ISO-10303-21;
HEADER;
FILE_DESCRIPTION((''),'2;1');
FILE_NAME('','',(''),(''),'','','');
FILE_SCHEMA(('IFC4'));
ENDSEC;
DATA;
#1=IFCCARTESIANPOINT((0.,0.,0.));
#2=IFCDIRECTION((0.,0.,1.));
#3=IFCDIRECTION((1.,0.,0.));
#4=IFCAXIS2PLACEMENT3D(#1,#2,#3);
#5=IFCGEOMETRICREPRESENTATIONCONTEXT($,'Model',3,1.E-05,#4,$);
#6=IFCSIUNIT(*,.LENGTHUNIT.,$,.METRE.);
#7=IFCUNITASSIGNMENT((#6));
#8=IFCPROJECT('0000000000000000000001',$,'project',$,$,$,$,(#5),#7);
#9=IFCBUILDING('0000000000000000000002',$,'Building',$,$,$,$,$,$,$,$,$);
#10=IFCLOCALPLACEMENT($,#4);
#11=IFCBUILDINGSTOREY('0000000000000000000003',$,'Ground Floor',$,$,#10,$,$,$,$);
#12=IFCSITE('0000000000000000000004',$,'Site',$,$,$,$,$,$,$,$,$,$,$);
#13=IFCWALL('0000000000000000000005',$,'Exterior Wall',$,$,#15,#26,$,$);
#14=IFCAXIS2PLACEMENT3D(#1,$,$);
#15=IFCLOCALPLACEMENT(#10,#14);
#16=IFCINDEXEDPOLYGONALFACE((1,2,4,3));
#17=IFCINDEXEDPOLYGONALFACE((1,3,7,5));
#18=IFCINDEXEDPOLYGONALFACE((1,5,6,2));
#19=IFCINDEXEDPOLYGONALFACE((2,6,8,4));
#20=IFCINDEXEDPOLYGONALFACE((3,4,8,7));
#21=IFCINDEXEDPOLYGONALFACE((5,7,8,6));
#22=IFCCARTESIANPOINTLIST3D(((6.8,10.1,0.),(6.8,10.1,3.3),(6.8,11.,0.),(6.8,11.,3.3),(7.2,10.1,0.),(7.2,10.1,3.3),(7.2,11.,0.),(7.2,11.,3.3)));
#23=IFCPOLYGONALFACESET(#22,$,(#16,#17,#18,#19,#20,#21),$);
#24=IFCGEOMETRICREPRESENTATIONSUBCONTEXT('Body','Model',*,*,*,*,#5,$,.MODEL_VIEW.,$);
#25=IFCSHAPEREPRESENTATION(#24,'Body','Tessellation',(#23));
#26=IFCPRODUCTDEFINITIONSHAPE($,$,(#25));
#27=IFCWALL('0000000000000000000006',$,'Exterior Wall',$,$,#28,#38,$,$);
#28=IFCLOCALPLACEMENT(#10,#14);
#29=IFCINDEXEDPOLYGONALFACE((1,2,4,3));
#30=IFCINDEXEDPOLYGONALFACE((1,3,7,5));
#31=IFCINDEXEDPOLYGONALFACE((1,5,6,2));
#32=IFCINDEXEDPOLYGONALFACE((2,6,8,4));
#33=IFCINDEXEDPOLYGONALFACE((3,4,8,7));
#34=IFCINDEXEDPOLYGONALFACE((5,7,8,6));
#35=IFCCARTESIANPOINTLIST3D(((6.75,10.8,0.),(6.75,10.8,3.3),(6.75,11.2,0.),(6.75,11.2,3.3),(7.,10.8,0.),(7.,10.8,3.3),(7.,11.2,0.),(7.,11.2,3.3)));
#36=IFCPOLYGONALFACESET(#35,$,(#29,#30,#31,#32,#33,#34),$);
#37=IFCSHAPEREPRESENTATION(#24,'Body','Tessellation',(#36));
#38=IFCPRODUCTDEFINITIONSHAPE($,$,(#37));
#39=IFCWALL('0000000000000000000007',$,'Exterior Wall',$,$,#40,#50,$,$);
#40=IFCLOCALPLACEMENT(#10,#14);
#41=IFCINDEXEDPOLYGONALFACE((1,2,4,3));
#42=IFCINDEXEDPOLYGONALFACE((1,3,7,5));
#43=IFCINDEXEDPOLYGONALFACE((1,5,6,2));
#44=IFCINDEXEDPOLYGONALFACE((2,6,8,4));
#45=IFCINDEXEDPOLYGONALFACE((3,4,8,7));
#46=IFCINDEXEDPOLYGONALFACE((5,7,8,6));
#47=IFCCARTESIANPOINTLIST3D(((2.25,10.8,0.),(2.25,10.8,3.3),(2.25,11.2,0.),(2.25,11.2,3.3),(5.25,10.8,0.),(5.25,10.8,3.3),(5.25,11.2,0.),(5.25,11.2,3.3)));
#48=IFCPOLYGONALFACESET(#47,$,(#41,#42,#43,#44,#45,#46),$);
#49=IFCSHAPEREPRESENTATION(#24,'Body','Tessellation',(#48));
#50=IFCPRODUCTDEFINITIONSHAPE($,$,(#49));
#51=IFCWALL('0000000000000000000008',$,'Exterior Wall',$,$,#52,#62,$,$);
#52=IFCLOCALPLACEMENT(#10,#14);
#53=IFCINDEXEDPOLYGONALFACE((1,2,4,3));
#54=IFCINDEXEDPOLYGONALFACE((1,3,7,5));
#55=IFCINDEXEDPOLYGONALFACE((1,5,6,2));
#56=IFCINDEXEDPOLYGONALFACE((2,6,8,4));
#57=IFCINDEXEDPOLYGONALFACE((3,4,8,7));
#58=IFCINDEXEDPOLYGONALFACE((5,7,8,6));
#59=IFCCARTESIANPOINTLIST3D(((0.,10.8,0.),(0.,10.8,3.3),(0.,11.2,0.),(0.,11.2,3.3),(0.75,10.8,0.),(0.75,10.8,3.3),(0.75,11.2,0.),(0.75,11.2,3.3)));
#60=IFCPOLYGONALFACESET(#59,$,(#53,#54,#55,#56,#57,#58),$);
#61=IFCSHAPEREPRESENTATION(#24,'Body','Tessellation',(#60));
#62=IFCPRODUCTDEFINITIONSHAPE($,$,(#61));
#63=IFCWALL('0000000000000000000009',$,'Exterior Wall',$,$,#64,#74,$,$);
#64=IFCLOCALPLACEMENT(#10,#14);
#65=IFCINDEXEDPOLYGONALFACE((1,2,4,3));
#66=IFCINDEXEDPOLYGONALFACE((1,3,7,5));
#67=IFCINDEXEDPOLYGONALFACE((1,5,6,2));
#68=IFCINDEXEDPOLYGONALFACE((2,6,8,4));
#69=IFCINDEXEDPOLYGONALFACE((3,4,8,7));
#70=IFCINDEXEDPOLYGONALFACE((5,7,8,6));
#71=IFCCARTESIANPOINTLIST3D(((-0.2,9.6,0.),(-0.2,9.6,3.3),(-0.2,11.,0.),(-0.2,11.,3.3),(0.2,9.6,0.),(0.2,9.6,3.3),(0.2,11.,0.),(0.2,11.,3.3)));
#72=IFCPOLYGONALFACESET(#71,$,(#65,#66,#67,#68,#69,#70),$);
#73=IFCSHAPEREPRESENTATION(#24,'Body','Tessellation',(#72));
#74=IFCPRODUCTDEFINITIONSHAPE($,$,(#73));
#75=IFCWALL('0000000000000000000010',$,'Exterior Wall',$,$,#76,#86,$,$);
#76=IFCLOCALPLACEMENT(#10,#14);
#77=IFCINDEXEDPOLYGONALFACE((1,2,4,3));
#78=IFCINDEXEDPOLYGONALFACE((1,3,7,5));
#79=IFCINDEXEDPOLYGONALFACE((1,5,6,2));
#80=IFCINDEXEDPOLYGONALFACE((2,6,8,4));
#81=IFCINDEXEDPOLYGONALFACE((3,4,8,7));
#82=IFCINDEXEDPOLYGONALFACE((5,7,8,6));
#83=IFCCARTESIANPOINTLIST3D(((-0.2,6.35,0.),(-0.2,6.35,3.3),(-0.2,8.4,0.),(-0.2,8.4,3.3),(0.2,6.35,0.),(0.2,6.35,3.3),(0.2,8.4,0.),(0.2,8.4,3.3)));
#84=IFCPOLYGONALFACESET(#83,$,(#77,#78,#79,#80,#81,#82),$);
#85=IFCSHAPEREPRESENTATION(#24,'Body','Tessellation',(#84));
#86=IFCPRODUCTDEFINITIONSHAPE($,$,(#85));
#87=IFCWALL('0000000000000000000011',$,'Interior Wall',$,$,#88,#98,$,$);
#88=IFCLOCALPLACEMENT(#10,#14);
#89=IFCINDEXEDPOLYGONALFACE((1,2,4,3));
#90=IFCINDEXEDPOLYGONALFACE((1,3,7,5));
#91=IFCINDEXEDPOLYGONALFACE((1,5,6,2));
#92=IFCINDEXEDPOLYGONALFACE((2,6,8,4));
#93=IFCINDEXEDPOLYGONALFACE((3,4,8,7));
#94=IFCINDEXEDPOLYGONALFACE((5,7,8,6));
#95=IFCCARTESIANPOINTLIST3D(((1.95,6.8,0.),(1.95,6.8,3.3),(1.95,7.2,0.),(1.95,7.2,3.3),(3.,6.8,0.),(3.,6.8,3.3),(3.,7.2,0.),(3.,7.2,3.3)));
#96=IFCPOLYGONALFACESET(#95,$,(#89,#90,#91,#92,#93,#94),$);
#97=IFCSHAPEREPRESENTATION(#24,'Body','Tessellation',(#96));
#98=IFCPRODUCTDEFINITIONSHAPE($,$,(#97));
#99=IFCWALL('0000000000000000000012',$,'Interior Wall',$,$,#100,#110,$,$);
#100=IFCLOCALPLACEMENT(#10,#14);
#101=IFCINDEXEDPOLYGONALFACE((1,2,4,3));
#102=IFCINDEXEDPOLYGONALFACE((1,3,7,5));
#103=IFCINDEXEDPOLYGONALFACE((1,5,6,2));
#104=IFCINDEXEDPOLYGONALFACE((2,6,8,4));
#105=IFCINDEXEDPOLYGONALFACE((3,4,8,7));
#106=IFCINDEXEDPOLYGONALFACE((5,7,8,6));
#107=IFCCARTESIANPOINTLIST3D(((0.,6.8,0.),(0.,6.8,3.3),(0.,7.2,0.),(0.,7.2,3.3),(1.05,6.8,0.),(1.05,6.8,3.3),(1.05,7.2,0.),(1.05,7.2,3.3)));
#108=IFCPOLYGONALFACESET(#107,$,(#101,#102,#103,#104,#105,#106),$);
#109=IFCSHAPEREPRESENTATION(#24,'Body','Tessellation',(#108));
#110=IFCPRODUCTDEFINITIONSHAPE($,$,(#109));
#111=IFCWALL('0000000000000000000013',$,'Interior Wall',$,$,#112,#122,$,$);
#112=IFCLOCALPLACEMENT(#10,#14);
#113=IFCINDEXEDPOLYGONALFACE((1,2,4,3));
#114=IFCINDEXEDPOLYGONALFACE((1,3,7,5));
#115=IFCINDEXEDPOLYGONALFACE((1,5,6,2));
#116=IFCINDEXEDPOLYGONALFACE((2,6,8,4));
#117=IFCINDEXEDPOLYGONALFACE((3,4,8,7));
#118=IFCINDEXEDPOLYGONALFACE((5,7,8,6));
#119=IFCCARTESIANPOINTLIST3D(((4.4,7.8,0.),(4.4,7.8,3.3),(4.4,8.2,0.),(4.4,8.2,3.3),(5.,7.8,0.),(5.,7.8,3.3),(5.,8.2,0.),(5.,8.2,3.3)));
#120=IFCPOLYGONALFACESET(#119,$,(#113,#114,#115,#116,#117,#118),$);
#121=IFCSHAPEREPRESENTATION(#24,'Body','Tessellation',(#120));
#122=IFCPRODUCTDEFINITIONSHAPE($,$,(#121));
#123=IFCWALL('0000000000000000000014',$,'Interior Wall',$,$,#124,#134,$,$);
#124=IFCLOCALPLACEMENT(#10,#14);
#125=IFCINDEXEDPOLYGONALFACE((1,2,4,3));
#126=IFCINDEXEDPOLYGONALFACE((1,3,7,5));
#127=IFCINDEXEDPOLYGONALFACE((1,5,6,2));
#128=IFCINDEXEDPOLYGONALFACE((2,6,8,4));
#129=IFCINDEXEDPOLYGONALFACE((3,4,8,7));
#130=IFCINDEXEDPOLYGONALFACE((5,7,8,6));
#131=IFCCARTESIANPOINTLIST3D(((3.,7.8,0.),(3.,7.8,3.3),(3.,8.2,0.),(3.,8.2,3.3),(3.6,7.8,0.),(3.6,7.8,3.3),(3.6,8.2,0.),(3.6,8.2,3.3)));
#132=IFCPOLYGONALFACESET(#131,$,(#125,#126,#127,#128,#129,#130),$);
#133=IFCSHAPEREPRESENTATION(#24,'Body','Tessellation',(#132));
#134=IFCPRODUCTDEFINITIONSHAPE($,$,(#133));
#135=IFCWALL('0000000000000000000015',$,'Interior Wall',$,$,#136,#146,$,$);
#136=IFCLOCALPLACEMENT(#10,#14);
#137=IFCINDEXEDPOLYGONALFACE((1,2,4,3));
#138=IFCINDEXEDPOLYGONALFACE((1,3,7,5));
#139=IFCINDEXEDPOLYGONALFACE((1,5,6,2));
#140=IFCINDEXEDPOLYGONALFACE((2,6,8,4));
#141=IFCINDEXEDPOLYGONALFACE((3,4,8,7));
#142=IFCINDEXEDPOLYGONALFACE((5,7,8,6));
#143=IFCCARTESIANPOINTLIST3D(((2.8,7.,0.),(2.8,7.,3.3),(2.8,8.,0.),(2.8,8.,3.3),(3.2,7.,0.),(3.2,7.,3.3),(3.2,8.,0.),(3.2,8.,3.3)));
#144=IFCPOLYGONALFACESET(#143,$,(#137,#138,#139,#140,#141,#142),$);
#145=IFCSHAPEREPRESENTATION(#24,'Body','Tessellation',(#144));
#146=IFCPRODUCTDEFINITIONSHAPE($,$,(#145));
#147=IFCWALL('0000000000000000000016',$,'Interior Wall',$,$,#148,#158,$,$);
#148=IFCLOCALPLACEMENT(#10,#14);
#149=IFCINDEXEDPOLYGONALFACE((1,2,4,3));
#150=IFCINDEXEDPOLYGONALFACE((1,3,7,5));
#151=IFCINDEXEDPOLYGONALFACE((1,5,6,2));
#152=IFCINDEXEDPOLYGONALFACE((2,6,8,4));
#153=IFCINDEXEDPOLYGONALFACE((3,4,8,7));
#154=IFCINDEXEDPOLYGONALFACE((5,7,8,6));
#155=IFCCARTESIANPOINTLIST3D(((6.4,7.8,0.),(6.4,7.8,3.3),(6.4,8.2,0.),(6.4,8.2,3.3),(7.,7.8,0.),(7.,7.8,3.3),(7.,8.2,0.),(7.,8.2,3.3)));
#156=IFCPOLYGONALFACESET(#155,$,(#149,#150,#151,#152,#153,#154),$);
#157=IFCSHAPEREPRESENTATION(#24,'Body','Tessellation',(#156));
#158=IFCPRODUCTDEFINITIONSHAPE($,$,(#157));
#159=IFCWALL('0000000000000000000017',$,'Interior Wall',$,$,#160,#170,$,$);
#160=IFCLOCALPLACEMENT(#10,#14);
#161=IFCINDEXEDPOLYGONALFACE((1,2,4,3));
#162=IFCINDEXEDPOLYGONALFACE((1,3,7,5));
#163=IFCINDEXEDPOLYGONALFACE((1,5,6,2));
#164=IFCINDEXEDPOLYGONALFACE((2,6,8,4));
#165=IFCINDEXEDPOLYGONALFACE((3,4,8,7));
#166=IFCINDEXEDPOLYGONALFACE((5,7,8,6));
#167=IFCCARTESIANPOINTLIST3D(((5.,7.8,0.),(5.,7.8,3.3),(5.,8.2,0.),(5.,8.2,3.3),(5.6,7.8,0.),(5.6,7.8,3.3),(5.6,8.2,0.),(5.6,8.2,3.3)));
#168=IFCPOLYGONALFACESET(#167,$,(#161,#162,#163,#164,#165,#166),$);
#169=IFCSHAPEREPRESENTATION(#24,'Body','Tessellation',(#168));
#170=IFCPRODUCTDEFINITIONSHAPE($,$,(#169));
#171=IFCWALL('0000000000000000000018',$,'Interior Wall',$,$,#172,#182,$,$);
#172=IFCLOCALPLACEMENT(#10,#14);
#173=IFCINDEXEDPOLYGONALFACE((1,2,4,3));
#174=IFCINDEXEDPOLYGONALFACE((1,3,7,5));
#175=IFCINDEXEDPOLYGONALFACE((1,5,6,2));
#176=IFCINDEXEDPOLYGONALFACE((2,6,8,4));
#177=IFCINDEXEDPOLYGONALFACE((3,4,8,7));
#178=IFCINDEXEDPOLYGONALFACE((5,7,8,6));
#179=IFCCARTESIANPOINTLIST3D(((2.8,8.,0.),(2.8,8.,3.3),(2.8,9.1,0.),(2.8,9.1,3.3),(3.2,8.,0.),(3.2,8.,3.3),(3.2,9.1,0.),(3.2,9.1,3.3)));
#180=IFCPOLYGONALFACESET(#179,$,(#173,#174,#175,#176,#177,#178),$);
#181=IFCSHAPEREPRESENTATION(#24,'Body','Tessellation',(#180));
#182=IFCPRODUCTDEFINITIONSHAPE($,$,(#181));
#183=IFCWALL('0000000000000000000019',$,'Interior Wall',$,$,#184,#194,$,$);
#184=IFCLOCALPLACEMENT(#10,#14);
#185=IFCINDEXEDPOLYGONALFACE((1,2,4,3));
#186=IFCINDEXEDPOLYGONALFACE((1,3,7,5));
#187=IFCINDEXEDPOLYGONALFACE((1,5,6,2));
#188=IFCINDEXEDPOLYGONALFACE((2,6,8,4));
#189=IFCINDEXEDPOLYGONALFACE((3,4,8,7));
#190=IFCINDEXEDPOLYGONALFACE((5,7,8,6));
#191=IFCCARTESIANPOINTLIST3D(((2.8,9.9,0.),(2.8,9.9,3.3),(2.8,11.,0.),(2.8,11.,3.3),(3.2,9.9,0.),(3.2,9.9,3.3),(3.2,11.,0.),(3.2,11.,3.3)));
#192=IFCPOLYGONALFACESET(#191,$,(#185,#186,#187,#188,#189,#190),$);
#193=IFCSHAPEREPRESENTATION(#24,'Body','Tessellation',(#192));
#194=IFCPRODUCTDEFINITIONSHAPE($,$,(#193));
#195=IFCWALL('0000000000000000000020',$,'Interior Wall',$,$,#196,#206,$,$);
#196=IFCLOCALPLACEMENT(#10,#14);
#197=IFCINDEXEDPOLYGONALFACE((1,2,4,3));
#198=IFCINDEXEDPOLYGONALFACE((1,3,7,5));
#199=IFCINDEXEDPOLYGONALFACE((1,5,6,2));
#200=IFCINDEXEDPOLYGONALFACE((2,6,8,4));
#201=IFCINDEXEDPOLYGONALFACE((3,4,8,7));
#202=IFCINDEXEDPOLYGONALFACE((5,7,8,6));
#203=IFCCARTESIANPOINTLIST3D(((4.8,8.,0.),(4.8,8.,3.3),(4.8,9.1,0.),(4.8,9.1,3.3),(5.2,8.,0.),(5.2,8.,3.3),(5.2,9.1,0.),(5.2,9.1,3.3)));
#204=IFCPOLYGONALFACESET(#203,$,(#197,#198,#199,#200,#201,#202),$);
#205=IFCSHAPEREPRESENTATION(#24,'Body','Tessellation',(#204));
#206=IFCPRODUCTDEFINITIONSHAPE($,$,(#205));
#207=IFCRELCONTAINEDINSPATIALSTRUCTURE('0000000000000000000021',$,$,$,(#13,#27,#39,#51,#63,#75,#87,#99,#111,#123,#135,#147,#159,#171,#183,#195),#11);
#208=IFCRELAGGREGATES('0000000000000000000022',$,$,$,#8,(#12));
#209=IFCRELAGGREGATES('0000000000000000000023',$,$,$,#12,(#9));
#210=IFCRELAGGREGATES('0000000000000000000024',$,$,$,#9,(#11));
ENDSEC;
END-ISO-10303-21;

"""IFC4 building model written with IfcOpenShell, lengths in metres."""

from ifc_helpers import new_model, si_unit, frame, origin_with_axes, place, context, subcontext, project, spatial, indexed_curve, outline, extrude, element, save


model = new_model("IFC4")

# Units and contexts
model_context = context("Model", 3, precision=1e-05, world=origin_with_axes())
body_context = subcontext(model_context, "Body", "Model", "MODEL_VIEW")
ifc_project = project(units=[si_unit("LENGTHUNIT", "METRE")], contexts=[model_context])

# Site, building, storey
site = spatial("IfcSite", under=ifc_project, Name="Site")
building = spatial("IfcBuilding", under=site, Name="Building")
storey_placement = place(None, origin_with_axes())
storey = spatial("IfcBuildingStorey", under=building, at=storey_placement, Name="Ground Floor")

# Walls
wall_1_placement = place(storey_placement, frame((7.0, 10.1, 0.0), z_axis=(0.0, 0.0, 1.0), x_axis=(0.0, 1.0, 0.0)))
element("IfcWall", 1, at=wall_1_placement, inside=storey, Name="Exterior Wall", context=body_context, shape_type="SweptSolid", body=[
    extrude(outline(indexed_curve([(0.0, 0.0), (0.0, 0.4), (0.9, 0.4), (0.9, 0.0), (0.0, 0.0)], self_intersect=False)), frame((0.0, -0.2, 0.0), z_axis=(0.0, 0.0, 1.0), x_axis=(1.0, 0.0, 0.0)), (0.0, 0.0, 1.0), 3.3),
])
wall_2_placement = place(storey_placement, frame((7.0, 11.0, 0.0), z_axis=(0.0, 0.0, 1.0), x_axis=(-1.0, 0.0, 0.0)))
element("IfcWall", 2, at=wall_2_placement, inside=storey, Name="Exterior Wall", context=body_context, shape_type="SweptSolid", body=[
    extrude(outline(indexed_curve([(0.0, 0.0), (0.0, 0.4), (0.25, 0.4), (0.25, 0.0), (0.0, 0.0)], self_intersect=False)), frame((0.0, -0.2, 0.0), z_axis=(0.0, 0.0, 1.0), x_axis=(1.0, 0.0, 0.0)), (0.0, 0.0, 1.0), 3.3),
])
wall_3_placement = place(storey_placement, frame((5.25, 11.0, 0.0), z_axis=(0.0, 0.0, 1.0), x_axis=(-1.0, 0.0, 0.0)))
element("IfcWall", 3, at=wall_3_placement, inside=storey, Name="Exterior Wall", context=body_context, shape_type="SweptSolid", body=[
    extrude(outline(indexed_curve([(0.0, 0.0), (0.0, 0.4), (3.0, 0.4), (3.0, 0.0), (0.0, 0.0)], self_intersect=False)), frame((0.0, -0.2, 0.0), z_axis=(0.0, 0.0, 1.0), x_axis=(1.0, 0.0, 0.0)), (0.0, 0.0, 1.0), 3.3),
])
wall_4_placement = place(storey_placement, frame((0.75, 11.0, 0.0), z_axis=(0.0, 0.0, 1.0), x_axis=(-1.0, 0.0, 0.0)))
element("IfcWall", 4, at=wall_4_placement, inside=storey, Name="Exterior Wall", context=body_context, shape_type="SweptSolid", body=[
    extrude(outline(indexed_curve([(0.0, 0.0), (0.0, 0.4), (0.75, 0.4), (0.75, 0.0), (0.0, 0.0)], self_intersect=False)), frame((0.0, -0.2, 0.0), z_axis=(0.0, 0.0, 1.0), x_axis=(1.0, 0.0, 0.0)), (0.0, 0.0, 1.0), 3.3),
])
wall_5_placement = place(storey_placement, frame((0.0, 11.0, 0.0), z_axis=(0.0, 0.0, 1.0), x_axis=(0.0, -1.0, 0.0)))
element("IfcWall", 5, at=wall_5_placement, inside=storey, Name="Exterior Wall", context=body_context, shape_type="SweptSolid", body=[
    extrude(outline(indexed_curve([(0.0, 0.0), (0.0, 0.4), (1.4, 0.4), (1.4, 0.0), (0.0, 0.0)], self_intersect=False)), frame((0.0, -0.2, 0.0), z_axis=(0.0, 0.0, 1.0), x_axis=(1.0, 0.0, 0.0)), (0.0, 0.0, 1.0), 3.3),
])
wall_6_placement = place(storey_placement, frame((0.0, 8.4, 0.0), z_axis=(0.0, 0.0, 1.0), x_axis=(0.0, -1.0, 0.0)))
element("IfcWall", 6, at=wall_6_placement, inside=storey, Name="Exterior Wall", context=body_context, shape_type="SweptSolid", body=[
    extrude(outline(indexed_curve([(0.0, 0.0), (0.0, 0.4), (2.05, 0.4), (2.05, 0.0), (0.0, 0.0)], self_intersect=False)), frame((0.0, -0.2, 0.0), z_axis=(0.0, 0.0, 1.0), x_axis=(1.0, 0.0, 0.0)), (0.0, 0.0, 1.0), 3.3),
])
for number, where, z_axis, x_axis, name in (
    (7, (3.0, 7.0, 0.0), (0.0, 0.0, 1.0), (-1.0, 0.0, 0.0), "Interior Wall"),
    (8, (1.05, 7.0, 0.0), (0.0, 0.0, 1.0), (-1.0, 0.0, 0.0), "Interior Wall"),
):
    element("IfcWall", number, at=place(storey_placement, frame(where, z_axis=z_axis, x_axis=x_axis)), inside=storey, Name=name, context=body_context, shape_type="SweptSolid", body=[
        extrude(outline(indexed_curve([(0.0, 0.0), (0.0, 0.4), (1.05, 0.4), (1.05, 0.0), (0.0, 0.0)], self_intersect=False)), frame((0.0, -0.2, 0.0), z_axis=(0.0, 0.0, 1.0), x_axis=(1.0, 0.0, 0.0)), (0.0, 0.0, 1.0), 3.3),
    ])
wall_7_placement = place(storey_placement, frame((5.0, 8.0, 0.0), z_axis=(0.0, 0.0, 1.0), x_axis=(-1.0, 0.0, 0.0)))
element("IfcWall", 9, at=wall_7_placement, inside=storey, Name="Interior Wall", context=body_context, shape_type="SweptSolid", body=[
    extrude(outline(indexed_curve([(0.0, 0.0), (0.0, 0.4), (0.6, 0.4), (0.6, 0.0), (0.0, 0.0)], self_intersect=False)), frame((0.0, -0.2, 0.0), z_axis=(0.0, 0.0, 1.0), x_axis=(1.0, 0.0, 0.0)), (0.0, 0.0, 1.0), 3.3),
])
wall_8_placement = place(storey_placement, frame((3.6, 8.0, 0.0), z_axis=(0.0, 0.0, 1.0), x_axis=(-1.0, 0.0, 0.0)))
element("IfcWall", 10, at=wall_8_placement, inside=storey, Name="Interior Wall", context=body_context, shape_type="SweptSolid", body=[
    extrude(outline(indexed_curve([(0.0, 0.0), (0.0, 0.4), (0.6, 0.4), (0.6, 0.0), (0.0, 0.0)], self_intersect=False)), frame((0.0, -0.2, 0.0), z_axis=(0.0, 0.0, 1.0), x_axis=(1.0, 0.0, 0.0)), (0.0, 0.0, 1.0), 3.3),
])
wall_9_placement = place(storey_placement, frame((3.0, 8.0, 0.0), z_axis=(0.0, 0.0, 1.0), x_axis=(0.0, -1.0, 0.0)))
element("IfcWall", 11, at=wall_9_placement, inside=storey, Name="Interior Wall", context=body_context, shape_type="SweptSolid", body=[
    extrude(outline(indexed_curve([(0.0, 0.0), (0.0, 0.4), (1.0, 0.4), (1.0, 0.0), (0.0, 0.0)], self_intersect=False)), frame((0.0, -0.2, 0.0), z_axis=(0.0, 0.0, 1.0), x_axis=(1.0, 0.0, 0.0)), (0.0, 0.0, 1.0), 3.3),
])
for number, where, z_axis, x_axis, name in (
    (12, (7.0, 8.0, 0.0), (0.0, 0.0, 1.0), (-1.0, 0.0, 0.0), "Interior Wall"),
    (13, (5.6, 8.0, 0.0), (0.0, 0.0, 1.0), (-1.0, 0.0, 0.0), "Interior Wall"),
):
    element("IfcWall", number, at=place(storey_placement, frame(where, z_axis=z_axis, x_axis=x_axis)), inside=storey, Name=name, context=body_context, shape_type="SweptSolid", body=[
        extrude(outline(indexed_curve([(0.0, 0.0), (0.0, 0.4), (0.6, 0.4), (0.6, 0.0), (0.0, 0.0)], self_intersect=False)), frame((0.0, -0.2, 0.0), z_axis=(0.0, 0.0, 1.0), x_axis=(1.0, 0.0, 0.0)), (0.0, 0.0, 1.0), 3.3),
    ])
for number, where, z_axis, x_axis, name in (
    (14, (3.0, 8.0, 0.0), (0.0, 0.0, 1.0), (0.0, 1.0, 0.0), "Interior Wall"),
    (15, (3.0, 9.9, 0.0), (0.0, 0.0, 1.0), (0.0, 1.0, 0.0), "Interior Wall"),
    (16, (5.0, 8.0, 0.0), (0.0, 0.0, 1.0), (0.0, 1.0, 0.0), "Interior Wall"),
):
    element("IfcWall", number, at=place(storey_placement, frame(where, z_axis=z_axis, x_axis=x_axis)), inside=storey, Name=name, context=body_context, shape_type="SweptSolid", body=[
        extrude(outline(indexed_curve([(0.0, 0.0), (0.0, 0.4), (1.1, 0.4), (1.1, 0.0), (0.0, 0.0)], self_intersect=False)), frame((0.0, -0.2, 0.0), z_axis=(0.0, 0.0, 1.0), x_axis=(1.0, 0.0, 0.0)), (0.0, 0.0, 1.0), 3.3),
    ])

save(model, "model.ifc")
